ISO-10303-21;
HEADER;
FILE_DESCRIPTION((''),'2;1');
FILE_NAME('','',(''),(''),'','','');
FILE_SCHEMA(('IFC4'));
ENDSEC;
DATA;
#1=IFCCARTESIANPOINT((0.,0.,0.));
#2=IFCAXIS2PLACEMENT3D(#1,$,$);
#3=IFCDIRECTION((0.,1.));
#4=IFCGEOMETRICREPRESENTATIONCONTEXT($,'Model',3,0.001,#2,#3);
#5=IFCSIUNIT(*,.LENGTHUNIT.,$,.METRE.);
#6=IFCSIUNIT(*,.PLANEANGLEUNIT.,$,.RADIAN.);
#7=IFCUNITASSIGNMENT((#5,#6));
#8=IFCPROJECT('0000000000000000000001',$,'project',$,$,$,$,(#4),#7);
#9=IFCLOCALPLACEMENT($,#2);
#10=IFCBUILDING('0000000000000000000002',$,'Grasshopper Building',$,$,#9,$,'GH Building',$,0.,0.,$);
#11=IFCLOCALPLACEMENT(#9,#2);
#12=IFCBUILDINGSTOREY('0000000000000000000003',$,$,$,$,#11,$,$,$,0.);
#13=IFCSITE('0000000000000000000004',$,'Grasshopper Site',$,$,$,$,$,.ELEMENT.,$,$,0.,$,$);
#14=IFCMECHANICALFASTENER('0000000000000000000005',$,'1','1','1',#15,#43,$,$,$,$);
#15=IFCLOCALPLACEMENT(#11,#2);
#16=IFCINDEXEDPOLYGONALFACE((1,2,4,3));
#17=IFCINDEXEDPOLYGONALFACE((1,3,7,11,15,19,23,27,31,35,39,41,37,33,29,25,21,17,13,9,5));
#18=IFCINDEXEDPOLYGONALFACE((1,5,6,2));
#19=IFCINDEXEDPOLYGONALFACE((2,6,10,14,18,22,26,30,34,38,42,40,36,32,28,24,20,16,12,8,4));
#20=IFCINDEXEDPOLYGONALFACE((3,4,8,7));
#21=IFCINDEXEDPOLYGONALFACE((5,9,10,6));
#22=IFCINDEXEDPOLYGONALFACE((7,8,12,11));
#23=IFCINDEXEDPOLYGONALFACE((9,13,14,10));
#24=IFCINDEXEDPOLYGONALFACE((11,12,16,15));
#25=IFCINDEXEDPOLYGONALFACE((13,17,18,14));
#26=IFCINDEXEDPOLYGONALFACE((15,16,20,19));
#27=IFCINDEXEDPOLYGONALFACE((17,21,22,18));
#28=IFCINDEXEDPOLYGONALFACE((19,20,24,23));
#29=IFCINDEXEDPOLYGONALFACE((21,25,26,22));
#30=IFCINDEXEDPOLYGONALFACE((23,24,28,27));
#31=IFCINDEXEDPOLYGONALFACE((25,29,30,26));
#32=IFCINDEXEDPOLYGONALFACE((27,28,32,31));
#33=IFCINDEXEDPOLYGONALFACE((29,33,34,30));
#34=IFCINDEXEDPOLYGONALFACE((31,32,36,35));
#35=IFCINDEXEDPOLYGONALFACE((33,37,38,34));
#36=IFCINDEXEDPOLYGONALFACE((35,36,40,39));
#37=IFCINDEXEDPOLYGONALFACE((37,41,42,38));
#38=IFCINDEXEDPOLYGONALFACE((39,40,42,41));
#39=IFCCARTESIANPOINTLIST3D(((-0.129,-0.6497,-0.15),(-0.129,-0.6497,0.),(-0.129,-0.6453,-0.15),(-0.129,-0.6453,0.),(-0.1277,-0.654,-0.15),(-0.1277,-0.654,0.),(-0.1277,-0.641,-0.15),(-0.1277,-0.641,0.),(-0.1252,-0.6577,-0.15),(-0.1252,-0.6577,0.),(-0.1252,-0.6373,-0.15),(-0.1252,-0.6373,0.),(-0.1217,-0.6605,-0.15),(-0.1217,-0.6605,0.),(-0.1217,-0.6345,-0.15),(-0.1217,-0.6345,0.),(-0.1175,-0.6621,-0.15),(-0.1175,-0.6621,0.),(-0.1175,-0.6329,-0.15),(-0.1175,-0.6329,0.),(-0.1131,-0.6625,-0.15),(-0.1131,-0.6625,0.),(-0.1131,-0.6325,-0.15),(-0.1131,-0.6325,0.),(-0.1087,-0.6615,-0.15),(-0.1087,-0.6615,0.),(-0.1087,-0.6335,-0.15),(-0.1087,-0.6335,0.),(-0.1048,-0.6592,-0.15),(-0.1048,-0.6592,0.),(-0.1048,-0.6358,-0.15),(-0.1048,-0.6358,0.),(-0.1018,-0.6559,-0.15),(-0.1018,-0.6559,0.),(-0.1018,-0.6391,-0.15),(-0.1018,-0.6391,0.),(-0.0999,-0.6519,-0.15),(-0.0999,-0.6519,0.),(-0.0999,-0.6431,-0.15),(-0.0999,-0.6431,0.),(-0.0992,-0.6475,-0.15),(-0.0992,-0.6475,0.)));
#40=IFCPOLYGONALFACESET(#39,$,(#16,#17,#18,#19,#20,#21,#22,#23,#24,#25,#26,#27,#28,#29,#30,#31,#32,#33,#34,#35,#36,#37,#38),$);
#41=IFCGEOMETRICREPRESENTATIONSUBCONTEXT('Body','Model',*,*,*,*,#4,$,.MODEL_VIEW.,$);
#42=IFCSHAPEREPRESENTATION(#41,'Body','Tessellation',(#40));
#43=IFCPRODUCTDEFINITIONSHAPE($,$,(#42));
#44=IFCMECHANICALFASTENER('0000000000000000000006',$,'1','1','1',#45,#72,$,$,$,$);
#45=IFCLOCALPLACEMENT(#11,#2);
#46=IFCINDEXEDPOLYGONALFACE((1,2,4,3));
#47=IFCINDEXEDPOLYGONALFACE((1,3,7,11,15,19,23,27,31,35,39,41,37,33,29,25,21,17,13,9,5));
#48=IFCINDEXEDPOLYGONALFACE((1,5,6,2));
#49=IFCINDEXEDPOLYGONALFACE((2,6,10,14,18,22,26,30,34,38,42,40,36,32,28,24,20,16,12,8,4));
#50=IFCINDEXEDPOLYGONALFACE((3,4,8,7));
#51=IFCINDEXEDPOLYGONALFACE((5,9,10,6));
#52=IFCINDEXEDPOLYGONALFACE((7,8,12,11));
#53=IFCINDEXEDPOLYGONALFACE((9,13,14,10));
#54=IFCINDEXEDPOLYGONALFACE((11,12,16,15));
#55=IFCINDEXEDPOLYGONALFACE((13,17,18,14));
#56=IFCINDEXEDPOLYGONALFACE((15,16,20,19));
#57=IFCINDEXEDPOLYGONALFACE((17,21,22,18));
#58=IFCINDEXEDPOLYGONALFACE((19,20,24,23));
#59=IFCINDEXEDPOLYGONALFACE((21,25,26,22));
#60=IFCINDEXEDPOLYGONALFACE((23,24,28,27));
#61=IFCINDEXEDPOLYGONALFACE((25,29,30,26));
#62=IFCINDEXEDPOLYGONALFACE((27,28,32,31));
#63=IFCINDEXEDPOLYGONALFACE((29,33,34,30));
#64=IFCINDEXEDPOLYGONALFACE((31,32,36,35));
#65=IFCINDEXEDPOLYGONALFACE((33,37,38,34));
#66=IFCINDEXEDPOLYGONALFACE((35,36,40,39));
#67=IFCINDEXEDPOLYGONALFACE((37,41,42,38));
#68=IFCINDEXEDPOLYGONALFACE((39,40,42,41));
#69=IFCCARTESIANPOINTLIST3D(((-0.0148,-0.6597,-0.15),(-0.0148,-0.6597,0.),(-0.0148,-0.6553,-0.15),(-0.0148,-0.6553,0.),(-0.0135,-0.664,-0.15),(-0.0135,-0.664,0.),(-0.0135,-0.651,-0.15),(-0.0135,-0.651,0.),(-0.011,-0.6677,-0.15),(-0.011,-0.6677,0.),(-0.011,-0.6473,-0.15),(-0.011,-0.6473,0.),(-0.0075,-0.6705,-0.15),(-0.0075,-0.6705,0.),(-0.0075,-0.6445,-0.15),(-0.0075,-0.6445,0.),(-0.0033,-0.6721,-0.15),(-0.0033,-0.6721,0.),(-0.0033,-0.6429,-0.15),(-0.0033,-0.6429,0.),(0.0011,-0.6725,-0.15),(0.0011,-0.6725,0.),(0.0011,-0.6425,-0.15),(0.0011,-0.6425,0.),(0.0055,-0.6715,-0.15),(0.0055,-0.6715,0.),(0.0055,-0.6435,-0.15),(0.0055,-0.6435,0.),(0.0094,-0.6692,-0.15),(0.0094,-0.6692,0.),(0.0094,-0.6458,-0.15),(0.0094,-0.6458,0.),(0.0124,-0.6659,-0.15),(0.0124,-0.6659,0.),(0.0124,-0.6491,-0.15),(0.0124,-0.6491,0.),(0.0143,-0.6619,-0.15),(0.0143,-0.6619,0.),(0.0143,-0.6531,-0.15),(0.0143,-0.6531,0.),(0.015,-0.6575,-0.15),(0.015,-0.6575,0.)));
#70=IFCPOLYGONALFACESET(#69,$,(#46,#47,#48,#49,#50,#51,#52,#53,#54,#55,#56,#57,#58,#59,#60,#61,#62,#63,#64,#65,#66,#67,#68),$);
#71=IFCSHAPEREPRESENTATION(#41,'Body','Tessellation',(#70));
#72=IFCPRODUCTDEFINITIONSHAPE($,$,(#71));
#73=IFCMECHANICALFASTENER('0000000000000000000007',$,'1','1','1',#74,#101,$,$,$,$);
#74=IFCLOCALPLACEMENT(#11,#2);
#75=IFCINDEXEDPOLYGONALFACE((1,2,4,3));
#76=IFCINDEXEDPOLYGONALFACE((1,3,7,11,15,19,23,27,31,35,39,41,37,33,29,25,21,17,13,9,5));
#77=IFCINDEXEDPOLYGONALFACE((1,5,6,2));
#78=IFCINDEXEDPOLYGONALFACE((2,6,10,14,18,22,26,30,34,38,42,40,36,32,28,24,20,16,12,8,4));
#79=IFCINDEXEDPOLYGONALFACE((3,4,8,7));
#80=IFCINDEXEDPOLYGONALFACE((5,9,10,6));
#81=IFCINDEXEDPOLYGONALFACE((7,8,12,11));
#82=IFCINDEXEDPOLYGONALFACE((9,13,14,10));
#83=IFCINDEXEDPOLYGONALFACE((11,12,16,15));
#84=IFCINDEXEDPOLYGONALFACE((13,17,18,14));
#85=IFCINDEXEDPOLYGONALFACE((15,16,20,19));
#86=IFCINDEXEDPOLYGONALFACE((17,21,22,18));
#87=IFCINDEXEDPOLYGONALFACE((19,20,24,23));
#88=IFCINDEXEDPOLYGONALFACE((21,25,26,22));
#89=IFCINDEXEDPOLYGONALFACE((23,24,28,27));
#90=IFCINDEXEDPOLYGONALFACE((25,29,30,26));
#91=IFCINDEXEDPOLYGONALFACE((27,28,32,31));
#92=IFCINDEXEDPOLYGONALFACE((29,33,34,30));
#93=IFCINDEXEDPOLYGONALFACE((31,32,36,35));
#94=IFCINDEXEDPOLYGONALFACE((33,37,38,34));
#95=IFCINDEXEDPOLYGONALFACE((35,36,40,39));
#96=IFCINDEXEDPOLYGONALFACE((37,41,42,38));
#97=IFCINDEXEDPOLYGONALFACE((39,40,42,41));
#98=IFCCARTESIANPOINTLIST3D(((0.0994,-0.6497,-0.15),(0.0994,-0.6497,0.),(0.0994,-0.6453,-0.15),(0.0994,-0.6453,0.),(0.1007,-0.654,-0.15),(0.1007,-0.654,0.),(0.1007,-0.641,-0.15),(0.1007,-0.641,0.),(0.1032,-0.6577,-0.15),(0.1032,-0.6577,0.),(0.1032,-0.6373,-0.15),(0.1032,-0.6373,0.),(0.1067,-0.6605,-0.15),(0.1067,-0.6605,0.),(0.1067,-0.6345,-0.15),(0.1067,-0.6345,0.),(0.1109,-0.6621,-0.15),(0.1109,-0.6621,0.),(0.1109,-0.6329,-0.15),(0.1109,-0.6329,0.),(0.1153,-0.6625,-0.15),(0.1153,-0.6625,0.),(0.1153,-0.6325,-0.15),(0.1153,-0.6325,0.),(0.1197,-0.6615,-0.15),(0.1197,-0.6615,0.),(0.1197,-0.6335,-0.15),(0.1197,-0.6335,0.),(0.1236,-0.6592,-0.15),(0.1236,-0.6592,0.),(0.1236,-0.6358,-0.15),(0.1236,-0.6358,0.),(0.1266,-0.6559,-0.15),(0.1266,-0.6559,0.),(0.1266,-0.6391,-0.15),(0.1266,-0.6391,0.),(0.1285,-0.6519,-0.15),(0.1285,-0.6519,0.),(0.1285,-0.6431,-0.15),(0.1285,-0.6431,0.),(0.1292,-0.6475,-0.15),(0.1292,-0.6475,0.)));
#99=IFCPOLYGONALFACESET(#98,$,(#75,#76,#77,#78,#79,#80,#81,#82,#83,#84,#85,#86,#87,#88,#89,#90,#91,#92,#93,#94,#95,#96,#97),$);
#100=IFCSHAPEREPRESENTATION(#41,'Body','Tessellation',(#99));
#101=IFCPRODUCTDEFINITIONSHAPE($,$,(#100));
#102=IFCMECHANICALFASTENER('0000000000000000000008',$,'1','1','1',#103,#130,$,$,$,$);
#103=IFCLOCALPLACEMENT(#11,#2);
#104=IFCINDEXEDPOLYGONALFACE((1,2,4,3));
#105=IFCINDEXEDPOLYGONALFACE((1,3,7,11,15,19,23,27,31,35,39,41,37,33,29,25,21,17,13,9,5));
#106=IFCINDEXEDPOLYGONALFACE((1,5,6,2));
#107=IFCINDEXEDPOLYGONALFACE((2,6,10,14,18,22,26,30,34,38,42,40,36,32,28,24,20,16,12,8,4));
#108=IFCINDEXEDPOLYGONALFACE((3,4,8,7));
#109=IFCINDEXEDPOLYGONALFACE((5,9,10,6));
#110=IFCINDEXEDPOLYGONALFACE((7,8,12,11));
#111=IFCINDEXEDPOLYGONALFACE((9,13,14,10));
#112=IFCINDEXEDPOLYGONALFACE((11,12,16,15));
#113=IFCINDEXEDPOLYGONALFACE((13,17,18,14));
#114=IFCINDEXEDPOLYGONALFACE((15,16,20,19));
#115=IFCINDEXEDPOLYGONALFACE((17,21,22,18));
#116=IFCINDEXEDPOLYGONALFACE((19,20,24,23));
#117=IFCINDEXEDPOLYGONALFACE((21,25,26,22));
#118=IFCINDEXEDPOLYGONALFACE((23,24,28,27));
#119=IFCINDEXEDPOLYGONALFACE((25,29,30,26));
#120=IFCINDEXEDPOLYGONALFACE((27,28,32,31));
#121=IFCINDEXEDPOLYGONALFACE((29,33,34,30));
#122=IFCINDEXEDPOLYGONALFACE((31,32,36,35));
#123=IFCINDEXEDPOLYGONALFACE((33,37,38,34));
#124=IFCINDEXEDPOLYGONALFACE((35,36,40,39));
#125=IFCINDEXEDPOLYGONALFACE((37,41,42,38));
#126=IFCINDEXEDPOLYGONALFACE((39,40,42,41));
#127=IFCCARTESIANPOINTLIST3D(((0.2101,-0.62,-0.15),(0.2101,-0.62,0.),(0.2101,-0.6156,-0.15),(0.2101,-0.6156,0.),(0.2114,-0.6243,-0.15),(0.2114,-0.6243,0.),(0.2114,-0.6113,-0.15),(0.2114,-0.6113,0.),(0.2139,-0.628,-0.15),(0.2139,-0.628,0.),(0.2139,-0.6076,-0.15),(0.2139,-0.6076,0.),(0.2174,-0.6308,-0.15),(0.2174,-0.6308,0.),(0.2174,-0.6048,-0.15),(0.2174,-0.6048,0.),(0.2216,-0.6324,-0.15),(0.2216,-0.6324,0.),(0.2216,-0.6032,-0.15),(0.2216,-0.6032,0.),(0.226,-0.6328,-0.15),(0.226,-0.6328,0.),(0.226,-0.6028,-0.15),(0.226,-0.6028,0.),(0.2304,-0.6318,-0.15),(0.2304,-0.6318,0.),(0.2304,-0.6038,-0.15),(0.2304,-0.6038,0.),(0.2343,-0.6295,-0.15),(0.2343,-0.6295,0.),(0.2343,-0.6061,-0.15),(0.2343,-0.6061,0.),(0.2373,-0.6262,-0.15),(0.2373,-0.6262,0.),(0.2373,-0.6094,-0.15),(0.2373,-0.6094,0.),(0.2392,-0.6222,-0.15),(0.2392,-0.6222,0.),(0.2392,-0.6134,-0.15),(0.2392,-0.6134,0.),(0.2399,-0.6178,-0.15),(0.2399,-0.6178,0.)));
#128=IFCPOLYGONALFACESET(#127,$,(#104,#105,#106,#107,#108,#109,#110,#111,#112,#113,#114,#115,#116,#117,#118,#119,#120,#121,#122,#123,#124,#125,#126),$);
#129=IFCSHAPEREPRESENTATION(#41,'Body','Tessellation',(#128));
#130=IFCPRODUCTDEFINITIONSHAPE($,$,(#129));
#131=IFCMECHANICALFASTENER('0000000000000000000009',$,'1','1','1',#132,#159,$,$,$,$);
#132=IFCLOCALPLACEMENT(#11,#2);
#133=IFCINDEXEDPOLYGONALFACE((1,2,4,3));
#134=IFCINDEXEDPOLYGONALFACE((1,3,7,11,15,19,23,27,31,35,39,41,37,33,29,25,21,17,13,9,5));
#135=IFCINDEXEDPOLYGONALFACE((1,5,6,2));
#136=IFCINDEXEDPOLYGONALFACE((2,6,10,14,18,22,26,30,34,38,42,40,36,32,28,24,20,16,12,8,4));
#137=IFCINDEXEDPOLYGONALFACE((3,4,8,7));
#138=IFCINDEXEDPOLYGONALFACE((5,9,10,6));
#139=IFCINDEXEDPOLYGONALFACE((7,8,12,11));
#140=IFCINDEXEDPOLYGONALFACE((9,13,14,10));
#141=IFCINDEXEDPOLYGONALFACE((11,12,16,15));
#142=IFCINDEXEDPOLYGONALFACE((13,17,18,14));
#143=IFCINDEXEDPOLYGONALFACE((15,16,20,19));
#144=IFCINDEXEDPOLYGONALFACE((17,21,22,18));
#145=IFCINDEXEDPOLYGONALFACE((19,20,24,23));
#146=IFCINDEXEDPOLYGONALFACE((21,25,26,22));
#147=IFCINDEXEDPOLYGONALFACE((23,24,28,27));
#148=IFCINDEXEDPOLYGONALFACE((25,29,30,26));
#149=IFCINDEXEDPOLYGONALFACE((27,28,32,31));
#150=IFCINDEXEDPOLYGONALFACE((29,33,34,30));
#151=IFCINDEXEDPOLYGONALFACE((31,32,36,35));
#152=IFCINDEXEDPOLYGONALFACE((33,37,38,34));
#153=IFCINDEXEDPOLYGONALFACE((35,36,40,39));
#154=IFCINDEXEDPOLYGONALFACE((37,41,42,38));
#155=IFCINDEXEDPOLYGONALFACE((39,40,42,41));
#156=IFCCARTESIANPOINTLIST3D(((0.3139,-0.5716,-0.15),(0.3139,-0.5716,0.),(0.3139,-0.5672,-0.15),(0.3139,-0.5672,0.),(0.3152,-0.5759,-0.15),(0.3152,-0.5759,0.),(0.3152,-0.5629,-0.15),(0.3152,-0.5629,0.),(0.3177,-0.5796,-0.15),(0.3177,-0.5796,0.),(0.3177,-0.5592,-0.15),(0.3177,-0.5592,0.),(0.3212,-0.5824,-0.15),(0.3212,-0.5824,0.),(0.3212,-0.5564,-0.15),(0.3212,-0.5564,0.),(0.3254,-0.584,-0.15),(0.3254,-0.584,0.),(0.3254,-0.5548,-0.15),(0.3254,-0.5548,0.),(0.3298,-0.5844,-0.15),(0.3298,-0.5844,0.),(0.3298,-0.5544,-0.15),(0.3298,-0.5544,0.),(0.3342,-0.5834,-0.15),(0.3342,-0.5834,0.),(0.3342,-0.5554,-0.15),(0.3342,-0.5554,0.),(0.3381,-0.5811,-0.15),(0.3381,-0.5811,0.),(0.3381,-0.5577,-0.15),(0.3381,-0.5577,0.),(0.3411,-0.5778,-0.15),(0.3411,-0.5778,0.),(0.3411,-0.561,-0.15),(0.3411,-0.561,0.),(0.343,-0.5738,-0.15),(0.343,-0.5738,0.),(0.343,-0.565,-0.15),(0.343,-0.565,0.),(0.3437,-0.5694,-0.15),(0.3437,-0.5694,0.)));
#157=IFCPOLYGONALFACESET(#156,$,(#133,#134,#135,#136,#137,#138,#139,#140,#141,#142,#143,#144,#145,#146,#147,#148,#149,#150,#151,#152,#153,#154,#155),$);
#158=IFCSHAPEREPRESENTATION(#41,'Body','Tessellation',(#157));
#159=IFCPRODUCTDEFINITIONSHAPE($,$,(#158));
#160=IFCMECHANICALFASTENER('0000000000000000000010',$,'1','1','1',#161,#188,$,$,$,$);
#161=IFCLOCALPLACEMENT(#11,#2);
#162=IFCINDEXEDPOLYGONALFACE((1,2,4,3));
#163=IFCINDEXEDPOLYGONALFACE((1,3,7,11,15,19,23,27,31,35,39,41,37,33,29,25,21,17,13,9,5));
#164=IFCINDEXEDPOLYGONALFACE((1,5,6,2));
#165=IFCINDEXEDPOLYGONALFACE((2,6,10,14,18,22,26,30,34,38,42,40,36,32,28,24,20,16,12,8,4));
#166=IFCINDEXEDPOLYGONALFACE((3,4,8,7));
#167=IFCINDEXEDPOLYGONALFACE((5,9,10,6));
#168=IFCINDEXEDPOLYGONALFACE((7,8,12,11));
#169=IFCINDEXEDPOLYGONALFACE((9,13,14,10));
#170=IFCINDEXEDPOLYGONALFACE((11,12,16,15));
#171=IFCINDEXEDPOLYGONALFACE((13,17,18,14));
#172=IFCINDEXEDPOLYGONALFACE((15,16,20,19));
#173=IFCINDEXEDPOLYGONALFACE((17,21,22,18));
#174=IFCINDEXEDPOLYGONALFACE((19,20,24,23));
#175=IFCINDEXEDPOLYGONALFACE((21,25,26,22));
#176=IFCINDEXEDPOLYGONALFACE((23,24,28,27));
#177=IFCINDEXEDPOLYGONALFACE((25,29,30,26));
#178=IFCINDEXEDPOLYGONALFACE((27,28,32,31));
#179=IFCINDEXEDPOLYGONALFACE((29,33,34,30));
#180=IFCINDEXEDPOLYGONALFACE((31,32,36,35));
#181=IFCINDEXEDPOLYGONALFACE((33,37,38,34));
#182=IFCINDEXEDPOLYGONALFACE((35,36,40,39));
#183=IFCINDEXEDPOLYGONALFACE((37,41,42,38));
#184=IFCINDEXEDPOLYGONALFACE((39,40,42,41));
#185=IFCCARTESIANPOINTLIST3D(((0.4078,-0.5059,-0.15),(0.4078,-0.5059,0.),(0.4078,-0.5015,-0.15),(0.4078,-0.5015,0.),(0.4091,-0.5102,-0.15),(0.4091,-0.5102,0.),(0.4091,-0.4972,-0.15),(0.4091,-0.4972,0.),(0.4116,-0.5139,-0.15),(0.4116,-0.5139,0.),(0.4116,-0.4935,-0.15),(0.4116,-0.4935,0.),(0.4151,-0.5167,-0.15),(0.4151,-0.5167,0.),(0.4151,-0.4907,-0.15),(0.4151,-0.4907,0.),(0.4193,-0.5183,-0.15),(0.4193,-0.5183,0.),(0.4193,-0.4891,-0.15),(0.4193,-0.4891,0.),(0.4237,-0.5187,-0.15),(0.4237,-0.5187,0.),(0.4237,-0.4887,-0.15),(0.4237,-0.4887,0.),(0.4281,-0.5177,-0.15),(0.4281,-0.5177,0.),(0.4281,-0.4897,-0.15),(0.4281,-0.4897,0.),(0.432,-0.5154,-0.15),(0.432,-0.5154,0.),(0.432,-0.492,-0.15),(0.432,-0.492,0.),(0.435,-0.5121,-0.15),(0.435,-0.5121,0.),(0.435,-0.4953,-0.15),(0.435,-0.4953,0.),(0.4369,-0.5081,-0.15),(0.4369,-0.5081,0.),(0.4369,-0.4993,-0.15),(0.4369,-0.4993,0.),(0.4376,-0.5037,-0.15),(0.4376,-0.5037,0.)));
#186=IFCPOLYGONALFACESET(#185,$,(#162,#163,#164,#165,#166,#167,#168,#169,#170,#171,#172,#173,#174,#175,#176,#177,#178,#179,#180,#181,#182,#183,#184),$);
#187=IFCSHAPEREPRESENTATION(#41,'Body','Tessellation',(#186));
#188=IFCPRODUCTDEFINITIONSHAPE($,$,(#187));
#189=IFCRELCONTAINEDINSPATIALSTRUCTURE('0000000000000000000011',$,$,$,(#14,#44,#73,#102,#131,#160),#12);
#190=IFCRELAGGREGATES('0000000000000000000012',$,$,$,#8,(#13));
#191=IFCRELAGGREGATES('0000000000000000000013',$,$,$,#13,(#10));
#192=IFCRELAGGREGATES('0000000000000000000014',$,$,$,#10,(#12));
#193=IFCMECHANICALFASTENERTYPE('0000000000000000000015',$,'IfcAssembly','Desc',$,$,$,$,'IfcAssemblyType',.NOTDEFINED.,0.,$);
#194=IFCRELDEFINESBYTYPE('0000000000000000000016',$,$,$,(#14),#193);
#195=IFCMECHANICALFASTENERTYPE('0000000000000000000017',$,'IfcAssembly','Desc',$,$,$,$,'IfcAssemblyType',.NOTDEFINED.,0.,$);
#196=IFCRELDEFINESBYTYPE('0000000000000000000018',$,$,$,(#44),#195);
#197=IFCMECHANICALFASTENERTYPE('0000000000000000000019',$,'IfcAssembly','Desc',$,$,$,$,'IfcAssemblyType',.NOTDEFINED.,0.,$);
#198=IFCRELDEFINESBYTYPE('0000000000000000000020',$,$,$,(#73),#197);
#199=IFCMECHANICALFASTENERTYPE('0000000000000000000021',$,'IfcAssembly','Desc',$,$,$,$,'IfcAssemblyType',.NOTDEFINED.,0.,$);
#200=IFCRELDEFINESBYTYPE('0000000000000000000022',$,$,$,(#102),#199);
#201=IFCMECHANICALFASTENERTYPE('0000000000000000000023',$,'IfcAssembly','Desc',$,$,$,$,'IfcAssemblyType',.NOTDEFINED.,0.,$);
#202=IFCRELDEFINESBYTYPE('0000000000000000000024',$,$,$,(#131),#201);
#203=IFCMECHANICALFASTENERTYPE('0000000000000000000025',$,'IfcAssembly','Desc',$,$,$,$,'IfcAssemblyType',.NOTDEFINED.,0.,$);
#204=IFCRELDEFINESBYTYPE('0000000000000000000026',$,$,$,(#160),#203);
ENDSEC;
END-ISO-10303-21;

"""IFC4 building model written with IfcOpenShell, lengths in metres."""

from ifc_helpers import new_model, si_unit, direction, frame, origin, place, context, subcontext, project, spatial, circle, extrude, source, transform, mapped, type_object, type_shapes, element, save


model = new_model("IFC4")

# Units and contexts
model_context = context("Model", 3, precision=0.001, world=origin(), true_north=direction((0.0, 1.0)))
body_context = subcontext(model_context, "Body", "Model", "MODEL_VIEW")
ifc_project = project(units=[si_unit("LENGTHUNIT", "METRE"), si_unit("PLANEANGLEUNIT", "RADIAN")], contexts=[model_context])

# Site, building, storey
site = spatial("IfcSite", under=ifc_project, Name="Grasshopper Site", CompositionType="ELEMENT", RefElevation=0.0)
building_placement = place(None, origin())
building = spatial("IfcBuilding", under=site, at=building_placement, Name="Grasshopper Building", LongName="GH Building", ElevationOfRefHeight=0.0, ElevationOfTerrain=0.0)
storey_placement = place(building_placement, origin())
storey = spatial("IfcBuildingStorey", under=building, at=storey_placement, Elevation=0.0)

# Mechanical fasteners
mechanical_fastener_type_1 = type_object("IfcMechanicalFastenerType", Name="IfcAssembly", Description="Desc", ElementType="IfcAssemblyType", NominalDiameter=0.0)
shared_shape_1 = source(origin(), body_context, "Body", "SweptSolid", [
    extrude(circle(Radius=0.015), frame((-0.1142, -0.6475, 0.0), z_axis=(0.0, 0.0, -1.0), x_axis=(1.0, 0.0, 0.0)), (0.0, 0.0, 1.0), 0.15),
])
type_shapes(mechanical_fastener_type_1, [shared_shape_1])
mechanical_fastener_1_placement = place(storey_placement, origin())
element("IfcMechanicalFastener", 1, at=mechanical_fastener_1_placement, inside=storey, type_object=mechanical_fastener_type_1, Name="1", Description="1", ObjectType="1", context=body_context, shape_type="MappedRepresentation", body=[
    mapped(shared_shape_1, transform((0.0, 0.0, 0.0), scale=1.0)),
])
mechanical_fastener_type_2 = type_object("IfcMechanicalFastenerType", Name="IfcAssembly", Description="Desc", ElementType="IfcAssemblyType", NominalDiameter=0.0)
shared_shape_2 = source(origin(), body_context, "Body", "SweptSolid", [
    extrude(circle(Radius=0.015), frame((0.0, -0.6575, 0.0), z_axis=(0.0, 0.0, -1.0), x_axis=(1.0, 0.0, 0.0)), (0.0, 0.0, 1.0), 0.15),
])
type_shapes(mechanical_fastener_type_2, [shared_shape_2])
mechanical_fastener_2_placement = place(storey_placement, origin())
element("IfcMechanicalFastener", 2, at=mechanical_fastener_2_placement, inside=storey, type_object=mechanical_fastener_type_2, Name="1", Description="1", ObjectType="1", context=body_context, shape_type="MappedRepresentation", body=[
    mapped(shared_shape_2, transform((0.0, 0.0, 0.0), scale=1.0)),
])
mechanical_fastener_type_3 = type_object("IfcMechanicalFastenerType", Name="IfcAssembly", Description="Desc", ElementType="IfcAssemblyType", NominalDiameter=0.0)
shared_shape_3 = source(origin(), body_context, "Body", "SweptSolid", [
    extrude(circle(Radius=0.015), frame((0.1142, -0.6475, 0.0), z_axis=(0.0, 0.0, -1.0), x_axis=(1.0, 0.0, 0.0)), (0.0, 0.0, 1.0), 0.15),
])
type_shapes(mechanical_fastener_type_3, [shared_shape_3])
mechanical_fastener_3_placement = place(storey_placement, origin())
element("IfcMechanicalFastener", 3, at=mechanical_fastener_3_placement, inside=storey, type_object=mechanical_fastener_type_3, Name="1", Description="1", ObjectType="1", context=body_context, shape_type="MappedRepresentation", body=[
    mapped(shared_shape_3, transform((0.0, 0.0, 0.0), scale=1.0)),
])
mechanical_fastener_type_4 = type_object("IfcMechanicalFastenerType", Name="IfcAssembly", Description="Desc", ElementType="IfcAssemblyType", NominalDiameter=0.0)
shared_shape_4 = source(origin(), body_context, "Body", "SweptSolid", [
    extrude(circle(Radius=0.015), frame((0.2249, -0.6178, 0.0), z_axis=(0.0, 0.0, -1.0), x_axis=(1.0, 0.0, 0.0)), (0.0, 0.0, 1.0), 0.15),
])
type_shapes(mechanical_fastener_type_4, [shared_shape_4])
mechanical_fastener_4_placement = place(storey_placement, origin())
element("IfcMechanicalFastener", 4, at=mechanical_fastener_4_placement, inside=storey, type_object=mechanical_fastener_type_4, Name="1", Description="1", ObjectType="1", context=body_context, shape_type="MappedRepresentation", body=[
    mapped(shared_shape_4, transform((0.0, 0.0, 0.0), scale=1.0)),
])
mechanical_fastener_type_5 = type_object("IfcMechanicalFastenerType", Name="IfcAssembly", Description="Desc", ElementType="IfcAssemblyType", NominalDiameter=0.0)
shared_shape_5 = source(origin(), body_context, "Body", "SweptSolid", [
    extrude(circle(Radius=0.015), frame((0.3287, -0.5694, 0.0), z_axis=(0.0, 0.0, -1.0), x_axis=(1.0, 0.0, 0.0)), (0.0, 0.0, 1.0), 0.15),
])
type_shapes(mechanical_fastener_type_5, [shared_shape_5])
mechanical_fastener_5_placement = place(storey_placement, origin())
element("IfcMechanicalFastener", 5, at=mechanical_fastener_5_placement, inside=storey, type_object=mechanical_fastener_type_5, Name="1", Description="1", ObjectType="1", context=body_context, shape_type="MappedRepresentation", body=[
    mapped(shared_shape_5, transform((0.0, 0.0, 0.0), scale=1.0)),
])
mechanical_fastener_type_6 = type_object("IfcMechanicalFastenerType", Name="IfcAssembly", Description="Desc", ElementType="IfcAssemblyType", NominalDiameter=0.0)
shared_shape_6 = source(origin(), body_context, "Body", "SweptSolid", [
    extrude(circle(Radius=0.015), frame((0.4226, -0.5037, 0.0), z_axis=(0.0, 0.0, -1.0), x_axis=(1.0, 0.0, 0.0)), (0.0, 0.0, 1.0), 0.15),
])
type_shapes(mechanical_fastener_type_6, [shared_shape_6])
mechanical_fastener_6_placement = place(storey_placement, origin())
element("IfcMechanicalFastener", 6, at=mechanical_fastener_6_placement, inside=storey, type_object=mechanical_fastener_type_6, Name="1", Description="1", ObjectType="1", context=body_context, shape_type="MappedRepresentation", body=[
    mapped(shared_shape_6, transform((0.0, 0.0, 0.0), scale=1.0)),
])

save(model, "model.ifc")
